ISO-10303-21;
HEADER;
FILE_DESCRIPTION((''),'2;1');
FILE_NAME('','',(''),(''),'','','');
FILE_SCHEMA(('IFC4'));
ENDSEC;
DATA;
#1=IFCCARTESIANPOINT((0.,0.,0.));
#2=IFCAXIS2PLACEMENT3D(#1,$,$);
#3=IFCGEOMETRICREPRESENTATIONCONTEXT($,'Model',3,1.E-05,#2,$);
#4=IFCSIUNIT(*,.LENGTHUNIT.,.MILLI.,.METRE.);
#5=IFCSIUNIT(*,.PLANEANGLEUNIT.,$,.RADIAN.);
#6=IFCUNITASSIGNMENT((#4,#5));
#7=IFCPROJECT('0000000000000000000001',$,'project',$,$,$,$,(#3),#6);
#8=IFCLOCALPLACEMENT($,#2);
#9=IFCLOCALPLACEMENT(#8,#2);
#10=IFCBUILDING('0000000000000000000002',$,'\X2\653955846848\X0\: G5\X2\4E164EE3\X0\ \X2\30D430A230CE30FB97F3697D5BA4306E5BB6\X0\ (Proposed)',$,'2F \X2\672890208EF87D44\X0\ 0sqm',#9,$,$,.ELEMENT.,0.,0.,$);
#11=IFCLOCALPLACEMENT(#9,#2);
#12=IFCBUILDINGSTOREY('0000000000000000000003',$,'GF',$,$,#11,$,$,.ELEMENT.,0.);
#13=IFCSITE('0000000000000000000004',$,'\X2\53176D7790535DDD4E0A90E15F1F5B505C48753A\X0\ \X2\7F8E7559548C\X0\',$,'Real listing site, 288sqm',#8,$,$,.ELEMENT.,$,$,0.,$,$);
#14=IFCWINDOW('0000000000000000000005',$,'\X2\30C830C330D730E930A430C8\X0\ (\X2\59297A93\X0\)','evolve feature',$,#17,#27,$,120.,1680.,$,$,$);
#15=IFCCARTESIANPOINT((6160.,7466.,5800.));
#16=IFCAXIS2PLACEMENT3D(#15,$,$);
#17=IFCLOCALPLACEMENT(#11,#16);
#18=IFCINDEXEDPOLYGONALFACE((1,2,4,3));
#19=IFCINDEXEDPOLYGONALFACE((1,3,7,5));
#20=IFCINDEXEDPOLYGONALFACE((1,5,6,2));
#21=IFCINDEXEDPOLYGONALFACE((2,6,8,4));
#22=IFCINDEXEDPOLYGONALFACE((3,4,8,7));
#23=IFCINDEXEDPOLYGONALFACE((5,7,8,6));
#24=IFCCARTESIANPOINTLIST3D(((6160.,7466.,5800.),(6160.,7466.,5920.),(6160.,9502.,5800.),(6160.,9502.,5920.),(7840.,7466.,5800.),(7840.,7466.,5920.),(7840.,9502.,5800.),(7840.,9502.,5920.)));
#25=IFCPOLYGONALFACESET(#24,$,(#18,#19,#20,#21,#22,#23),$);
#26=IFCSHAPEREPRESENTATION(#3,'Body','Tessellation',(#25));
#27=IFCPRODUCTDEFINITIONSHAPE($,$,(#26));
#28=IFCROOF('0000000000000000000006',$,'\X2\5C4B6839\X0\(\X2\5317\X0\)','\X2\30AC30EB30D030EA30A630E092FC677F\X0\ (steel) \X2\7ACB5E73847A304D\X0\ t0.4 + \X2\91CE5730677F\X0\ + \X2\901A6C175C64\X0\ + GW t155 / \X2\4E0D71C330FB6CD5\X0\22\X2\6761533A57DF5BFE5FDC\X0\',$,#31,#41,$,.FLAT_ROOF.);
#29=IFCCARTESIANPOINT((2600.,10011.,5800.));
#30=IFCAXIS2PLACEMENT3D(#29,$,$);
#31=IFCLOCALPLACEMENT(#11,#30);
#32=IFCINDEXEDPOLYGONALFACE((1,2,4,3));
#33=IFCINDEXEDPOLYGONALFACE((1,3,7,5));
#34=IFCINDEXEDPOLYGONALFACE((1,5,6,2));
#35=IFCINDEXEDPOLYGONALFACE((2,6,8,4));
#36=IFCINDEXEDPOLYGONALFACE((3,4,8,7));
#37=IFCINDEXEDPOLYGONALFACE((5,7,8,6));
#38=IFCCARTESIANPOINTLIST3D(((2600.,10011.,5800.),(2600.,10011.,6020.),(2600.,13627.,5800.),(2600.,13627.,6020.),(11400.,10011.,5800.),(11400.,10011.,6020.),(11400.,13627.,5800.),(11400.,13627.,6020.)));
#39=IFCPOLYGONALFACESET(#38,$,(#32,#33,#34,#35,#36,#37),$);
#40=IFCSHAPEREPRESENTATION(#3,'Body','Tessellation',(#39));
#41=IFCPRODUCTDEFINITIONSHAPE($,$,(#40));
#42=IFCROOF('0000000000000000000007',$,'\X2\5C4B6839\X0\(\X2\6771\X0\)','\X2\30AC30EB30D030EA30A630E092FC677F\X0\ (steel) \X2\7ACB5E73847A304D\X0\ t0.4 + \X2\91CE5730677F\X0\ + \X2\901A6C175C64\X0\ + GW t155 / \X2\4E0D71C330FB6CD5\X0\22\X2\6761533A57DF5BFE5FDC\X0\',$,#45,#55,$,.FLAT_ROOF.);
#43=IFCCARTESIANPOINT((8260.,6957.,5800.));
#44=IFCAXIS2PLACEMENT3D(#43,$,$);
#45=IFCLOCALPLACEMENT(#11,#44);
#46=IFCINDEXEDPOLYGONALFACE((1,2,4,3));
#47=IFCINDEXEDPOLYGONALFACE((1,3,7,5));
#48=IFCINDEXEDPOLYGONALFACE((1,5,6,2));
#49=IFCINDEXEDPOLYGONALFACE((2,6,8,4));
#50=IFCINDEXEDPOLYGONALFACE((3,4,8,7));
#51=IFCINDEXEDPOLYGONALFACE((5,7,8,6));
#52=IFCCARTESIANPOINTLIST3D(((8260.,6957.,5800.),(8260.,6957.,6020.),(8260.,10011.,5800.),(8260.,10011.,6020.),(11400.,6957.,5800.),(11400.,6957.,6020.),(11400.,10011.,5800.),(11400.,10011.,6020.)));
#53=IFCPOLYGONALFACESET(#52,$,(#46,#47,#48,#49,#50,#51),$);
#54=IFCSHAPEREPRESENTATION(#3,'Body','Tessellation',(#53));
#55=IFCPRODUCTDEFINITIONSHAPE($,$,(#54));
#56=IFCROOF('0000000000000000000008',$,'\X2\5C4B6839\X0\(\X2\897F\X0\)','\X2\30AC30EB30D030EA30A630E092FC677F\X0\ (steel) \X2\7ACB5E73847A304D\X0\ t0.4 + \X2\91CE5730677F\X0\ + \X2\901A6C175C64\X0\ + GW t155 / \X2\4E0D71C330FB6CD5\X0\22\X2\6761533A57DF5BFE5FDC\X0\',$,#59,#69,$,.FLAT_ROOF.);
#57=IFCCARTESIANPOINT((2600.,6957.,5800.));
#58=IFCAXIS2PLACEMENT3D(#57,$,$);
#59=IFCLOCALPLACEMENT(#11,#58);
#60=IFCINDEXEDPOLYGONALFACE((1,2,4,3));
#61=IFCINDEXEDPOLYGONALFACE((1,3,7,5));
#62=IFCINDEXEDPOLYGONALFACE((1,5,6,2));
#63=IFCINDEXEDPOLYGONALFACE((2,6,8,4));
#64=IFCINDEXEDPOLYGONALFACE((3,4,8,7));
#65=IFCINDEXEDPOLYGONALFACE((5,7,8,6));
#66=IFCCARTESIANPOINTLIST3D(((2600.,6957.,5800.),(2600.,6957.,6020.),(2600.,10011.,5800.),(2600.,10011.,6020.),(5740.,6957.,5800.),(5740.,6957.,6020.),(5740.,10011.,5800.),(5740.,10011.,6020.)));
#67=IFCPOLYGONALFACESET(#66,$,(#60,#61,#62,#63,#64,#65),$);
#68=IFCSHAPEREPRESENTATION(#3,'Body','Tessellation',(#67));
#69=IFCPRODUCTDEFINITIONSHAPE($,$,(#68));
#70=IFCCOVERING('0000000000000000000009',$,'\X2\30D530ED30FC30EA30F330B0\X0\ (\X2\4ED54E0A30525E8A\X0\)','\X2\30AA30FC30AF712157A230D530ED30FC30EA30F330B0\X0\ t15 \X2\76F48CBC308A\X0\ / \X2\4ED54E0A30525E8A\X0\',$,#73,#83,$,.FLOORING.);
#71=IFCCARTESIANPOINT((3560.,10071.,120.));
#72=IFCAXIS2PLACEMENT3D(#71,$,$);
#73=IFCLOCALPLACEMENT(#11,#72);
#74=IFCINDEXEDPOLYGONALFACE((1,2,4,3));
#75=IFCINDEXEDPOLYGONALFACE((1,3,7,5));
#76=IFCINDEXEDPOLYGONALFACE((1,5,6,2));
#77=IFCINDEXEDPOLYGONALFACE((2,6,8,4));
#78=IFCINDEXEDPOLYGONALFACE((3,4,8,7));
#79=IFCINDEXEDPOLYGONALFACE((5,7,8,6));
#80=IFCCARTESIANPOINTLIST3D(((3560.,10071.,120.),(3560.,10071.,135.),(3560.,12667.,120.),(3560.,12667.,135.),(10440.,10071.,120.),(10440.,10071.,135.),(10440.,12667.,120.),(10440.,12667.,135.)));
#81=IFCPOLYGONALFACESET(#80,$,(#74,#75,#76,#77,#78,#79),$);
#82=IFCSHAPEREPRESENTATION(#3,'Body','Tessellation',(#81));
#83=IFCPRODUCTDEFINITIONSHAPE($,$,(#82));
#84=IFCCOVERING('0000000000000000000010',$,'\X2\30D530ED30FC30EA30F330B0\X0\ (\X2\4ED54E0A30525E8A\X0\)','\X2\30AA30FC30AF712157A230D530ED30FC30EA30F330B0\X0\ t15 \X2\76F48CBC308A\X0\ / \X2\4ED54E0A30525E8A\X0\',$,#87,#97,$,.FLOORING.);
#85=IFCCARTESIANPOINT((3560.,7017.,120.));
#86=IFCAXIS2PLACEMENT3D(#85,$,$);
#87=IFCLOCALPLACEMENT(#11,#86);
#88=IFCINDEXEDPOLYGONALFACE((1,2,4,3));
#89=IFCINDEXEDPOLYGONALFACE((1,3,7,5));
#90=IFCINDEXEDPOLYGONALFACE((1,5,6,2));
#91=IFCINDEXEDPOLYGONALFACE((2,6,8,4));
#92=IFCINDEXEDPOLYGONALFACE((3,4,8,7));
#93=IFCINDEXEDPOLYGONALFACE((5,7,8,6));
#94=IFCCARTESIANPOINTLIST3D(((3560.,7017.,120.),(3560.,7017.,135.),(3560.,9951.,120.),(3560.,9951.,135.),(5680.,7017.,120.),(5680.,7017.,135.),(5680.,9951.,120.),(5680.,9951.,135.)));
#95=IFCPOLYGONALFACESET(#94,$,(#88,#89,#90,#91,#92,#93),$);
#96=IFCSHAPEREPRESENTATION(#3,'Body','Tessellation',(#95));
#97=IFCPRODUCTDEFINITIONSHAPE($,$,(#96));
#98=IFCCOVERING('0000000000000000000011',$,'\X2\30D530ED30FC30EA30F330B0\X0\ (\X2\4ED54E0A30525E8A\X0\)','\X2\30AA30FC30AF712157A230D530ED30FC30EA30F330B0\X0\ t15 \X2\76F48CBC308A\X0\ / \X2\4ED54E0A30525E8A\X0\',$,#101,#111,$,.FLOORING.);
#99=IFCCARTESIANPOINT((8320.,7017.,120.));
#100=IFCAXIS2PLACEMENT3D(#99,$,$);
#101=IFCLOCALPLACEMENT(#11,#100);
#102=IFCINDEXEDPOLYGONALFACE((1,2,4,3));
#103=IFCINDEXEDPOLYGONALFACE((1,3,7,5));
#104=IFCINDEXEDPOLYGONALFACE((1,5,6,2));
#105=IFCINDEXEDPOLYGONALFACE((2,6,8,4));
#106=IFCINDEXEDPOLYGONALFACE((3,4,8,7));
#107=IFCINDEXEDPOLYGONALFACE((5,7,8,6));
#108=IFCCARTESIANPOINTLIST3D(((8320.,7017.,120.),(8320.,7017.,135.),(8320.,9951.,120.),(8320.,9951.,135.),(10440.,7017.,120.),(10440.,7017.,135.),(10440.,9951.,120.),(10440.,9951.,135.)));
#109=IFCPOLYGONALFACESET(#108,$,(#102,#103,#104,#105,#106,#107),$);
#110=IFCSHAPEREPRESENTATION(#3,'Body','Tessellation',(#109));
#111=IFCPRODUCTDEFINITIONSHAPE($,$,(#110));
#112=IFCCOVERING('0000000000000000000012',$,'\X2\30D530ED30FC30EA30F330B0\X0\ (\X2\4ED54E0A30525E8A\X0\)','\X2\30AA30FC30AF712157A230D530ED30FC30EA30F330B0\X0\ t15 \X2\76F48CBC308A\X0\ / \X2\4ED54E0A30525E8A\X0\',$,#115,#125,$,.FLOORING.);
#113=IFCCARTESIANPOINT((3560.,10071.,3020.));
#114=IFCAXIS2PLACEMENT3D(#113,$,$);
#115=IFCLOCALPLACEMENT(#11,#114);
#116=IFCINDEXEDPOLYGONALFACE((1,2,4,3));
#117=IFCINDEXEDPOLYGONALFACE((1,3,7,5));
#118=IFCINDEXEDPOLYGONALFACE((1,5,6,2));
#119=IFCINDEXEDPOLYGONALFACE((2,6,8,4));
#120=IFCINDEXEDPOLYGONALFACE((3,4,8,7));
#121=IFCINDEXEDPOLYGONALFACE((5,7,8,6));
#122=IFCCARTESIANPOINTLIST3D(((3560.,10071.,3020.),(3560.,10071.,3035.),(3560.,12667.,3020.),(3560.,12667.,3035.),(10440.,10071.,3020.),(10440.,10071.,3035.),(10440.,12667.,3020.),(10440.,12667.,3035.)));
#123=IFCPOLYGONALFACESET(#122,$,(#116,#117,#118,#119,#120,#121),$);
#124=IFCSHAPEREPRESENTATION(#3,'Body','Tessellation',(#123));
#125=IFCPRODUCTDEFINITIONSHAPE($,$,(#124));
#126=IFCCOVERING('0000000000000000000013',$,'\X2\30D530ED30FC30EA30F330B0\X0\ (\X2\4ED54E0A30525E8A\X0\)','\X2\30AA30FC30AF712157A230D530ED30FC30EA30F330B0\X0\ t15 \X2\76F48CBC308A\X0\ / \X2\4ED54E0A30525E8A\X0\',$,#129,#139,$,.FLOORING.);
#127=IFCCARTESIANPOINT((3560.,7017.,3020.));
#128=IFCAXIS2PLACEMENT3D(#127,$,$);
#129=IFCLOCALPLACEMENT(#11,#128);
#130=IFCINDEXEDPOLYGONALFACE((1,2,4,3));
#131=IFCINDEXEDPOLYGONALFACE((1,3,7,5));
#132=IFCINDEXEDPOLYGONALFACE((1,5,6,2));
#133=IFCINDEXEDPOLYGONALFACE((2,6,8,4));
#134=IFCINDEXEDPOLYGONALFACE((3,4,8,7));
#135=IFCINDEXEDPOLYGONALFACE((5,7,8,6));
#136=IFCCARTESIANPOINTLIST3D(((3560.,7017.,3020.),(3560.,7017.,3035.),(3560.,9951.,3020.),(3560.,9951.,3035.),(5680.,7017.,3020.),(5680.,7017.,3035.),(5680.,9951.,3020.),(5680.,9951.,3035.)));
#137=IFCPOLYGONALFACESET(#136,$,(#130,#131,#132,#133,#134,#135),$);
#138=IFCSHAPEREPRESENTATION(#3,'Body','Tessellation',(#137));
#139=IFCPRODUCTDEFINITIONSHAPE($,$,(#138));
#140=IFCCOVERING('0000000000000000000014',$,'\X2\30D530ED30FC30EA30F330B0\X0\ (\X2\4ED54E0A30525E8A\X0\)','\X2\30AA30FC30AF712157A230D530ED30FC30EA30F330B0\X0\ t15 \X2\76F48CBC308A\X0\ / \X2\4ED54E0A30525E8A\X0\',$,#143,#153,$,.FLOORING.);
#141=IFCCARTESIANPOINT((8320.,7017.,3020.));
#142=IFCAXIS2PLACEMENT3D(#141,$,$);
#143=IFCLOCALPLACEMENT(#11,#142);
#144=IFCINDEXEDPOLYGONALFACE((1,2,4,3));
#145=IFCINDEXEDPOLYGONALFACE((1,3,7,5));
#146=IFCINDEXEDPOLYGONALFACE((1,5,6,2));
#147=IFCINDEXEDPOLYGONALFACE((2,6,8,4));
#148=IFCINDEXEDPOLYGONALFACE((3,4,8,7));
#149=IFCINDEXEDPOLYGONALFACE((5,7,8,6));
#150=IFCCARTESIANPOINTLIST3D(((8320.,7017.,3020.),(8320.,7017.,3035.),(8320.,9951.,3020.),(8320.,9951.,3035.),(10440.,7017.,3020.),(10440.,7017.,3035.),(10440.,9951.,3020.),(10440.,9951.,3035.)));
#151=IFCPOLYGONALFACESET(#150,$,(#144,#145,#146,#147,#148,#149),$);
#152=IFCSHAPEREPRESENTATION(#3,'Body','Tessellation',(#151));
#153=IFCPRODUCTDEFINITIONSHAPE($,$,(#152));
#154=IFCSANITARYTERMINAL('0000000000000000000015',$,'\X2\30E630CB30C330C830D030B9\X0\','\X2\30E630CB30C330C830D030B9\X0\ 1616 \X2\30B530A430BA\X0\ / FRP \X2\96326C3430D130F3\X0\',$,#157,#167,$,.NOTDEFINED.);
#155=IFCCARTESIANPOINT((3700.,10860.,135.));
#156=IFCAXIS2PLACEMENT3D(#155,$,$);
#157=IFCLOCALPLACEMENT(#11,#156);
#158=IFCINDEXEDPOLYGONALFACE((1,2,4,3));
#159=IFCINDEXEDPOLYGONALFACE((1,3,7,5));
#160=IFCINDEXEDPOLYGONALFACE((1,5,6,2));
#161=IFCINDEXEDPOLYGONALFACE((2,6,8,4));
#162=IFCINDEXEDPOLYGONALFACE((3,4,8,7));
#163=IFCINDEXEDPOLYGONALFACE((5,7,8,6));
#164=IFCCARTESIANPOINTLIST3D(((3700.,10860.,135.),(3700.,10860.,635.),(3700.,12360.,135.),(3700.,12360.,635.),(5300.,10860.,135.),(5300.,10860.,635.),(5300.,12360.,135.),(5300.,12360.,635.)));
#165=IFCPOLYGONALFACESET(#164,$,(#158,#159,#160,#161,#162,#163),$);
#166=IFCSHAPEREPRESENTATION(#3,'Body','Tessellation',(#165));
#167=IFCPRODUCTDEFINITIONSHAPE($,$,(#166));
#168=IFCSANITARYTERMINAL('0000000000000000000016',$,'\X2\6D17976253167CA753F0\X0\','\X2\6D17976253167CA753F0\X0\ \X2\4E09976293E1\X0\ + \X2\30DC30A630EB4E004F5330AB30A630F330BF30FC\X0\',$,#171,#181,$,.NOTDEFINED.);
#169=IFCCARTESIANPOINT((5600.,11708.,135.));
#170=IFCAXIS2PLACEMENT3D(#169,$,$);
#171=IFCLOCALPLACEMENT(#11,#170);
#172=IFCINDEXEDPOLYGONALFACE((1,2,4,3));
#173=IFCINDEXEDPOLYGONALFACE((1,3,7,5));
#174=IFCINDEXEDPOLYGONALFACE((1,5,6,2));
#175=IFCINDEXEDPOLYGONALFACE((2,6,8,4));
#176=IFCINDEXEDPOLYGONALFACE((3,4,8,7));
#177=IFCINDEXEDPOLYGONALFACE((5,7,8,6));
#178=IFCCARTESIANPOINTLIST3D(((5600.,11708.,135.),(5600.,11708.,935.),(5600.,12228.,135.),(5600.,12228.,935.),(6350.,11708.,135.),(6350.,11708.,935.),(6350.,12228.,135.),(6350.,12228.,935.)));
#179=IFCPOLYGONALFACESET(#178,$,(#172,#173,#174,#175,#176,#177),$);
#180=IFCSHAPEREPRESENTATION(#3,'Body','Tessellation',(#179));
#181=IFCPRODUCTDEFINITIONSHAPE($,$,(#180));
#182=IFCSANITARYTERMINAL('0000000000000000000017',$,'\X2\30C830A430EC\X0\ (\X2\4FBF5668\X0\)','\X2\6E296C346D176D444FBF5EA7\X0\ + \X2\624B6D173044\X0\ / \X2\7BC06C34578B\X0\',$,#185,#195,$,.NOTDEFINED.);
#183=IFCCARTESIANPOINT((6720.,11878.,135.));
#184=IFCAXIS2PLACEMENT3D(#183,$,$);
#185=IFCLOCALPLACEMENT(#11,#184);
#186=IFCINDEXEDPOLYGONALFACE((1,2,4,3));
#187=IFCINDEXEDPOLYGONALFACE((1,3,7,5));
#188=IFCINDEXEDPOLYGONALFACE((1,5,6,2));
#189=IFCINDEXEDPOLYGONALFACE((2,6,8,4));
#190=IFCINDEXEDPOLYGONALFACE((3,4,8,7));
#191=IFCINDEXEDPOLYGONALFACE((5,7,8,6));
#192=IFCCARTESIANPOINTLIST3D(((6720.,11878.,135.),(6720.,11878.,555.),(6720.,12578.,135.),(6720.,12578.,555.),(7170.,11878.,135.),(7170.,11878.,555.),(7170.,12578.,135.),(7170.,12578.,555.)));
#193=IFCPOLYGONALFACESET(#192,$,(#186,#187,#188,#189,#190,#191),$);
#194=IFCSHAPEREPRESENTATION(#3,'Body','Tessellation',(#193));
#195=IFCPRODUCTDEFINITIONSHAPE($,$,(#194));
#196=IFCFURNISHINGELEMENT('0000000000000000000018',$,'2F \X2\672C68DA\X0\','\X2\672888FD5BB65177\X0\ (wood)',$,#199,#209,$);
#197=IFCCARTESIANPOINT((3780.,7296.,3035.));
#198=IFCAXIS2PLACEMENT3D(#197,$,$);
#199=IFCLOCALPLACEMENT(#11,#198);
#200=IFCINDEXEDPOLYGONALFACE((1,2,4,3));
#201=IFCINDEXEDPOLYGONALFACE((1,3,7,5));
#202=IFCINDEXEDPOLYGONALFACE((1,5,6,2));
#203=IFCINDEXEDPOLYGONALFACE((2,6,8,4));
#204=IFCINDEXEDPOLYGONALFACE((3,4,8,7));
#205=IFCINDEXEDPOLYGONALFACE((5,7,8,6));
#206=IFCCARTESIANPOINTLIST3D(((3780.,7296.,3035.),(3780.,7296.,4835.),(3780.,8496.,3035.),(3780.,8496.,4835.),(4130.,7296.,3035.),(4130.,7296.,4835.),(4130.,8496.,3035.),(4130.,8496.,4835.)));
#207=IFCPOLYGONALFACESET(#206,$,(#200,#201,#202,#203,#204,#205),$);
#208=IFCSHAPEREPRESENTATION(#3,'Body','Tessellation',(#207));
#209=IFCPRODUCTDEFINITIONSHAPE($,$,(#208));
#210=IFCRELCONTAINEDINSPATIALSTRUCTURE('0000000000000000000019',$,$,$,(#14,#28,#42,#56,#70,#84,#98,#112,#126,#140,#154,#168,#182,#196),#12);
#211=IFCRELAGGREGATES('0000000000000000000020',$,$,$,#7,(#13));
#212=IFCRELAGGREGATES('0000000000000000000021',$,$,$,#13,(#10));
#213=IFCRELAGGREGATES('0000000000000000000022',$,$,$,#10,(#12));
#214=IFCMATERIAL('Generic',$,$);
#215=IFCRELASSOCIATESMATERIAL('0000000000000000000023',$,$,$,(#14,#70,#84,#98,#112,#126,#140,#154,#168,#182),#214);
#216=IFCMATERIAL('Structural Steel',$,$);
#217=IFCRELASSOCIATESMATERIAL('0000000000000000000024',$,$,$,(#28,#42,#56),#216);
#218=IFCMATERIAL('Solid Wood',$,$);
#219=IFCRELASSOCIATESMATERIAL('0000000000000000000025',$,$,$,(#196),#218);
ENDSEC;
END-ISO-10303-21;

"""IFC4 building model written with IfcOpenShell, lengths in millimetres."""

from ifc_helpers import new_model, si_unit, frame, frame_2d, origin, place, context, project, spatial, rectangle, extrude, material, element, save


model = new_model("IFC4")

# Units and contexts
model_context = context("Model", 3, precision=1e-05, world=origin())
ifc_project = project(units=[si_unit("LENGTHUNIT", "METRE", prefix="MILLI"), si_unit("PLANEANGLEUNIT", "RADIAN")], contexts=[model_context])

# Site, building, storey
site_placement = place(None, origin())
site = spatial("IfcSite", under=ifc_project, at=site_placement, Name="北海道川上郡弟子屈町 美留和", ObjectType="Real listing site, 288sqm", CompositionType="ELEMENT", RefElevation=0.0)
building_placement = place(site_placement, origin())
building = spatial("IfcBuilding", under=site, at=building_placement, Name="改善案: G5世代 ピアノ・音楽室の家 (Proposed)", ObjectType="2F 木造軸組 0sqm", CompositionType="ELEMENT", ElevationOfRefHeight=0.0, ElevationOfTerrain=0.0)
storey_placement = place(building_placement, origin())
storey = spatial("IfcBuildingStorey", under=building, at=storey_placement, Name="GF", CompositionType="ELEMENT", Elevation=0.0)

# Shared definitions
ifc_material_1 = material(Name="Solid Wood")

# Window
ifc_material_2 = material(Name="Generic")
window_1_placement = place(storey_placement, frame((6160.0, 7466.0, 5800.0)))
element("IfcWindow", 1, at=window_1_placement, inside=storey, material=ifc_material_2, Name="トップライト (天窓)", Description="evolve feature", OverallHeight=120.0, OverallWidth=1680.0, context=model_context, shape_type="SweptSolid", body=[
    extrude(rectangle(XDim=1680.0, YDim=2036.0, at=frame_2d((840.0, 1018.0))), frame((6160.0, 7466.0, 5800.0)), (0.0, 0.0, 1.0), 120.0),
])

# Roofs
ifc_material_3 = material(Name="Structural Steel")
roof_1_placement = place(storey_placement, frame((2600.0, 10011.0, 5800.0)))
element("IfcRoof", 2, at=roof_1_placement, inside=storey, material=ifc_material_3, Name="屋根(北)", Description="ガルバリウム鋼板 (steel) 立平葺き t0.4 + 野地板 + 通気層 + GW t155 / 不燃・法22条区域対応", PredefinedType="FLAT_ROOF", context=model_context, shape_type="SweptSolid", body=[
    extrude(rectangle(XDim=8800.0, YDim=3616.0, at=frame_2d((4400.0, 1808.0))), frame((2600.0, 10011.0, 5800.0)), (0.0, 0.0, 1.0), 220.0),
])
roof_2_placement = place(storey_placement, frame((8260.0, 6957.0, 5800.0)))
element("IfcRoof", 3, at=roof_2_placement, inside=storey, material=ifc_material_3, Name="屋根(東)", Description="ガルバリウム鋼板 (steel) 立平葺き t0.4 + 野地板 + 通気層 + GW t155 / 不燃・法22条区域対応", PredefinedType="FLAT_ROOF", context=model_context, shape_type="SweptSolid", body=[
    extrude(rectangle(XDim=3140.0, YDim=3054.0, at=frame_2d((1570.0, 1527.0))), frame((8260.0, 6957.0, 5800.0)), (0.0, 0.0, 1.0), 220.0),
])
roof_3_placement = place(storey_placement, frame((2600.0, 6957.0, 5800.0)))
element("IfcRoof", 4, at=roof_3_placement, inside=storey, material=ifc_material_3, Name="屋根(西)", Description="ガルバリウム鋼板 (steel) 立平葺き t0.4 + 野地板 + 通気層 + GW t155 / 不燃・法22条区域対応", PredefinedType="FLAT_ROOF", context=model_context, shape_type="SweptSolid", body=[
    extrude(rectangle(XDim=3140.0, YDim=3054.0, at=frame_2d((1570.0, 1527.0))), frame((2600.0, 6957.0, 5800.0)), (0.0, 0.0, 1.0), 220.0),
])

# Coverings
covering_1_placement = place(storey_placement, frame((3560.0, 10071.0, 120.0)))
element("IfcCovering", 5, at=covering_1_placement, inside=storey, material=ifc_material_2, Name="フローリング (仕上げ床)", Description="オーク無垢フローリング t15 直貼り / 仕上げ床", PredefinedType="FLOORING", context=model_context, shape_type="SweptSolid", body=[
    extrude(rectangle(XDim=6880.0, YDim=2596.0, at=frame_2d((3440.0, 1298.0))), frame((3560.0, 10071.0, 120.0)), (0.0, 0.0, 1.0), 15.0),
])
covering_2_placement = place(storey_placement, frame((3560.0, 7017.0, 120.0)))
element("IfcCovering", 6, at=covering_2_placement, inside=storey, material=ifc_material_2, Name="フローリング (仕上げ床)", Description="オーク無垢フローリング t15 直貼り / 仕上げ床", PredefinedType="FLOORING", context=model_context, shape_type="SweptSolid", body=[
    extrude(rectangle(XDim=2120.0, YDim=2934.0, at=frame_2d((1060.0, 1467.0))), frame((3560.0, 7017.0, 120.0)), (0.0, 0.0, 1.0), 15.0),
])
covering_3_placement = place(storey_placement, frame((8320.0, 7017.0, 120.0)))
element("IfcCovering", 7, at=covering_3_placement, inside=storey, material=ifc_material_2, Name="フローリング (仕上げ床)", Description="オーク無垢フローリング t15 直貼り / 仕上げ床", PredefinedType="FLOORING", context=model_context, shape_type="SweptSolid", body=[
    extrude(rectangle(XDim=2120.0, YDim=2934.0, at=frame_2d((1060.0, 1467.0))), frame((8320.0, 7017.0, 120.0)), (0.0, 0.0, 1.0), 15.0),
])
covering_4_placement = place(storey_placement, frame((3560.0, 10071.0, 3020.0)))
element("IfcCovering", 8, at=covering_4_placement, inside=storey, material=ifc_material_2, Name="フローリング (仕上げ床)", Description="オーク無垢フローリング t15 直貼り / 仕上げ床", PredefinedType="FLOORING", context=model_context, shape_type="SweptSolid", body=[
    extrude(rectangle(XDim=6880.0, YDim=2596.0, at=frame_2d((3440.0, 1298.0))), frame((3560.0, 10071.0, 3020.0)), (0.0, 0.0, 1.0), 15.0),
])
covering_5_placement = place(storey_placement, frame((3560.0, 7017.0, 3020.0)))
element("IfcCovering", 9, at=covering_5_placement, inside=storey, material=ifc_material_2, Name="フローリング (仕上げ床)", Description="オーク無垢フローリング t15 直貼り / 仕上げ床", PredefinedType="FLOORING", context=model_context, shape_type="SweptSolid", body=[
    extrude(rectangle(XDim=2120.0, YDim=2934.0, at=frame_2d((1060.0, 1467.0))), frame((3560.0, 7017.0, 3020.0)), (0.0, 0.0, 1.0), 15.0),
])
covering_6_placement = place(storey_placement, frame((8320.0, 7017.0, 3020.0)))
element("IfcCovering", 10, at=covering_6_placement, inside=storey, material=ifc_material_2, Name="フローリング (仕上げ床)", Description="オーク無垢フローリング t15 直貼り / 仕上げ床", PredefinedType="FLOORING", context=model_context, shape_type="SweptSolid", body=[
    extrude(rectangle(XDim=2120.0, YDim=2934.0, at=frame_2d((1060.0, 1467.0))), frame((8320.0, 7017.0, 3020.0)), (0.0, 0.0, 1.0), 15.0),
])

# Sanitary terminals
sanitary_terminal_1_placement = place(storey_placement, frame((3700.0, 10860.0, 135.0)))
element("IfcSanitaryTerminal", 11, at=sanitary_terminal_1_placement, inside=storey, material=ifc_material_2, Name="ユニットバス", Description="ユニットバス 1616 サイズ / FRP 防水パン", PredefinedType="NOTDEFINED", context=model_context, shape_type="SweptSolid", body=[
    extrude(rectangle(XDim=1600.0, YDim=1500.0, at=frame_2d((800.0, 750.0))), frame((3700.0, 10860.0, 135.0)), (0.0, 0.0, 1.0), 500.0),
])
sanitary_terminal_2_placement = place(storey_placement, frame((5600.0, 11708.0, 135.0)))
element("IfcSanitaryTerminal", 12, at=sanitary_terminal_2_placement, inside=storey, material=ifc_material_2, Name="洗面化粧台", Description="洗面化粧台 三面鏡 + ボウル一体カウンター", PredefinedType="NOTDEFINED", context=model_context, shape_type="SweptSolid", body=[
    extrude(rectangle(XDim=750.0, YDim=520.0, at=frame_2d((375.0, 260.0))), frame((5600.0, 11708.0, 135.0)), (0.0, 0.0, 1.0), 800.0),
])
sanitary_terminal_3_placement = place(storey_placement, frame((6720.0, 11878.0, 135.0)))
element("IfcSanitaryTerminal", 13, at=sanitary_terminal_3_placement, inside=storey, material=ifc_material_2, Name="トイレ (便器)", Description="温水洗浄便座 + 手洗い / 節水型", PredefinedType="NOTDEFINED", context=model_context, shape_type="SweptSolid", body=[
    extrude(rectangle(XDim=450.0, YDim=700.0, at=frame_2d((225.0, 350.0))), frame((6720.0, 11878.0, 135.0)), (0.0, 0.0, 1.0), 420.0),
])

# Furnishing element
furnishing_placement = place(storey_placement, frame((3780.0, 7296.0, 3035.0)))
element("IfcFurnishingElement", 14, at=furnishing_placement, inside=storey, material=ifc_material_1, Name="2F 本棚", Description="木製家具 (wood)", context=model_context, shape_type="SweptSolid", body=[
    extrude(rectangle(XDim=350.0, YDim=1200.0, at=frame_2d((175.0, 600.0))), frame((3780.0, 7296.0, 3035.0)), (0.0, 0.0, 1.0), 1800.0),
])

save(model, "model.ifc")
